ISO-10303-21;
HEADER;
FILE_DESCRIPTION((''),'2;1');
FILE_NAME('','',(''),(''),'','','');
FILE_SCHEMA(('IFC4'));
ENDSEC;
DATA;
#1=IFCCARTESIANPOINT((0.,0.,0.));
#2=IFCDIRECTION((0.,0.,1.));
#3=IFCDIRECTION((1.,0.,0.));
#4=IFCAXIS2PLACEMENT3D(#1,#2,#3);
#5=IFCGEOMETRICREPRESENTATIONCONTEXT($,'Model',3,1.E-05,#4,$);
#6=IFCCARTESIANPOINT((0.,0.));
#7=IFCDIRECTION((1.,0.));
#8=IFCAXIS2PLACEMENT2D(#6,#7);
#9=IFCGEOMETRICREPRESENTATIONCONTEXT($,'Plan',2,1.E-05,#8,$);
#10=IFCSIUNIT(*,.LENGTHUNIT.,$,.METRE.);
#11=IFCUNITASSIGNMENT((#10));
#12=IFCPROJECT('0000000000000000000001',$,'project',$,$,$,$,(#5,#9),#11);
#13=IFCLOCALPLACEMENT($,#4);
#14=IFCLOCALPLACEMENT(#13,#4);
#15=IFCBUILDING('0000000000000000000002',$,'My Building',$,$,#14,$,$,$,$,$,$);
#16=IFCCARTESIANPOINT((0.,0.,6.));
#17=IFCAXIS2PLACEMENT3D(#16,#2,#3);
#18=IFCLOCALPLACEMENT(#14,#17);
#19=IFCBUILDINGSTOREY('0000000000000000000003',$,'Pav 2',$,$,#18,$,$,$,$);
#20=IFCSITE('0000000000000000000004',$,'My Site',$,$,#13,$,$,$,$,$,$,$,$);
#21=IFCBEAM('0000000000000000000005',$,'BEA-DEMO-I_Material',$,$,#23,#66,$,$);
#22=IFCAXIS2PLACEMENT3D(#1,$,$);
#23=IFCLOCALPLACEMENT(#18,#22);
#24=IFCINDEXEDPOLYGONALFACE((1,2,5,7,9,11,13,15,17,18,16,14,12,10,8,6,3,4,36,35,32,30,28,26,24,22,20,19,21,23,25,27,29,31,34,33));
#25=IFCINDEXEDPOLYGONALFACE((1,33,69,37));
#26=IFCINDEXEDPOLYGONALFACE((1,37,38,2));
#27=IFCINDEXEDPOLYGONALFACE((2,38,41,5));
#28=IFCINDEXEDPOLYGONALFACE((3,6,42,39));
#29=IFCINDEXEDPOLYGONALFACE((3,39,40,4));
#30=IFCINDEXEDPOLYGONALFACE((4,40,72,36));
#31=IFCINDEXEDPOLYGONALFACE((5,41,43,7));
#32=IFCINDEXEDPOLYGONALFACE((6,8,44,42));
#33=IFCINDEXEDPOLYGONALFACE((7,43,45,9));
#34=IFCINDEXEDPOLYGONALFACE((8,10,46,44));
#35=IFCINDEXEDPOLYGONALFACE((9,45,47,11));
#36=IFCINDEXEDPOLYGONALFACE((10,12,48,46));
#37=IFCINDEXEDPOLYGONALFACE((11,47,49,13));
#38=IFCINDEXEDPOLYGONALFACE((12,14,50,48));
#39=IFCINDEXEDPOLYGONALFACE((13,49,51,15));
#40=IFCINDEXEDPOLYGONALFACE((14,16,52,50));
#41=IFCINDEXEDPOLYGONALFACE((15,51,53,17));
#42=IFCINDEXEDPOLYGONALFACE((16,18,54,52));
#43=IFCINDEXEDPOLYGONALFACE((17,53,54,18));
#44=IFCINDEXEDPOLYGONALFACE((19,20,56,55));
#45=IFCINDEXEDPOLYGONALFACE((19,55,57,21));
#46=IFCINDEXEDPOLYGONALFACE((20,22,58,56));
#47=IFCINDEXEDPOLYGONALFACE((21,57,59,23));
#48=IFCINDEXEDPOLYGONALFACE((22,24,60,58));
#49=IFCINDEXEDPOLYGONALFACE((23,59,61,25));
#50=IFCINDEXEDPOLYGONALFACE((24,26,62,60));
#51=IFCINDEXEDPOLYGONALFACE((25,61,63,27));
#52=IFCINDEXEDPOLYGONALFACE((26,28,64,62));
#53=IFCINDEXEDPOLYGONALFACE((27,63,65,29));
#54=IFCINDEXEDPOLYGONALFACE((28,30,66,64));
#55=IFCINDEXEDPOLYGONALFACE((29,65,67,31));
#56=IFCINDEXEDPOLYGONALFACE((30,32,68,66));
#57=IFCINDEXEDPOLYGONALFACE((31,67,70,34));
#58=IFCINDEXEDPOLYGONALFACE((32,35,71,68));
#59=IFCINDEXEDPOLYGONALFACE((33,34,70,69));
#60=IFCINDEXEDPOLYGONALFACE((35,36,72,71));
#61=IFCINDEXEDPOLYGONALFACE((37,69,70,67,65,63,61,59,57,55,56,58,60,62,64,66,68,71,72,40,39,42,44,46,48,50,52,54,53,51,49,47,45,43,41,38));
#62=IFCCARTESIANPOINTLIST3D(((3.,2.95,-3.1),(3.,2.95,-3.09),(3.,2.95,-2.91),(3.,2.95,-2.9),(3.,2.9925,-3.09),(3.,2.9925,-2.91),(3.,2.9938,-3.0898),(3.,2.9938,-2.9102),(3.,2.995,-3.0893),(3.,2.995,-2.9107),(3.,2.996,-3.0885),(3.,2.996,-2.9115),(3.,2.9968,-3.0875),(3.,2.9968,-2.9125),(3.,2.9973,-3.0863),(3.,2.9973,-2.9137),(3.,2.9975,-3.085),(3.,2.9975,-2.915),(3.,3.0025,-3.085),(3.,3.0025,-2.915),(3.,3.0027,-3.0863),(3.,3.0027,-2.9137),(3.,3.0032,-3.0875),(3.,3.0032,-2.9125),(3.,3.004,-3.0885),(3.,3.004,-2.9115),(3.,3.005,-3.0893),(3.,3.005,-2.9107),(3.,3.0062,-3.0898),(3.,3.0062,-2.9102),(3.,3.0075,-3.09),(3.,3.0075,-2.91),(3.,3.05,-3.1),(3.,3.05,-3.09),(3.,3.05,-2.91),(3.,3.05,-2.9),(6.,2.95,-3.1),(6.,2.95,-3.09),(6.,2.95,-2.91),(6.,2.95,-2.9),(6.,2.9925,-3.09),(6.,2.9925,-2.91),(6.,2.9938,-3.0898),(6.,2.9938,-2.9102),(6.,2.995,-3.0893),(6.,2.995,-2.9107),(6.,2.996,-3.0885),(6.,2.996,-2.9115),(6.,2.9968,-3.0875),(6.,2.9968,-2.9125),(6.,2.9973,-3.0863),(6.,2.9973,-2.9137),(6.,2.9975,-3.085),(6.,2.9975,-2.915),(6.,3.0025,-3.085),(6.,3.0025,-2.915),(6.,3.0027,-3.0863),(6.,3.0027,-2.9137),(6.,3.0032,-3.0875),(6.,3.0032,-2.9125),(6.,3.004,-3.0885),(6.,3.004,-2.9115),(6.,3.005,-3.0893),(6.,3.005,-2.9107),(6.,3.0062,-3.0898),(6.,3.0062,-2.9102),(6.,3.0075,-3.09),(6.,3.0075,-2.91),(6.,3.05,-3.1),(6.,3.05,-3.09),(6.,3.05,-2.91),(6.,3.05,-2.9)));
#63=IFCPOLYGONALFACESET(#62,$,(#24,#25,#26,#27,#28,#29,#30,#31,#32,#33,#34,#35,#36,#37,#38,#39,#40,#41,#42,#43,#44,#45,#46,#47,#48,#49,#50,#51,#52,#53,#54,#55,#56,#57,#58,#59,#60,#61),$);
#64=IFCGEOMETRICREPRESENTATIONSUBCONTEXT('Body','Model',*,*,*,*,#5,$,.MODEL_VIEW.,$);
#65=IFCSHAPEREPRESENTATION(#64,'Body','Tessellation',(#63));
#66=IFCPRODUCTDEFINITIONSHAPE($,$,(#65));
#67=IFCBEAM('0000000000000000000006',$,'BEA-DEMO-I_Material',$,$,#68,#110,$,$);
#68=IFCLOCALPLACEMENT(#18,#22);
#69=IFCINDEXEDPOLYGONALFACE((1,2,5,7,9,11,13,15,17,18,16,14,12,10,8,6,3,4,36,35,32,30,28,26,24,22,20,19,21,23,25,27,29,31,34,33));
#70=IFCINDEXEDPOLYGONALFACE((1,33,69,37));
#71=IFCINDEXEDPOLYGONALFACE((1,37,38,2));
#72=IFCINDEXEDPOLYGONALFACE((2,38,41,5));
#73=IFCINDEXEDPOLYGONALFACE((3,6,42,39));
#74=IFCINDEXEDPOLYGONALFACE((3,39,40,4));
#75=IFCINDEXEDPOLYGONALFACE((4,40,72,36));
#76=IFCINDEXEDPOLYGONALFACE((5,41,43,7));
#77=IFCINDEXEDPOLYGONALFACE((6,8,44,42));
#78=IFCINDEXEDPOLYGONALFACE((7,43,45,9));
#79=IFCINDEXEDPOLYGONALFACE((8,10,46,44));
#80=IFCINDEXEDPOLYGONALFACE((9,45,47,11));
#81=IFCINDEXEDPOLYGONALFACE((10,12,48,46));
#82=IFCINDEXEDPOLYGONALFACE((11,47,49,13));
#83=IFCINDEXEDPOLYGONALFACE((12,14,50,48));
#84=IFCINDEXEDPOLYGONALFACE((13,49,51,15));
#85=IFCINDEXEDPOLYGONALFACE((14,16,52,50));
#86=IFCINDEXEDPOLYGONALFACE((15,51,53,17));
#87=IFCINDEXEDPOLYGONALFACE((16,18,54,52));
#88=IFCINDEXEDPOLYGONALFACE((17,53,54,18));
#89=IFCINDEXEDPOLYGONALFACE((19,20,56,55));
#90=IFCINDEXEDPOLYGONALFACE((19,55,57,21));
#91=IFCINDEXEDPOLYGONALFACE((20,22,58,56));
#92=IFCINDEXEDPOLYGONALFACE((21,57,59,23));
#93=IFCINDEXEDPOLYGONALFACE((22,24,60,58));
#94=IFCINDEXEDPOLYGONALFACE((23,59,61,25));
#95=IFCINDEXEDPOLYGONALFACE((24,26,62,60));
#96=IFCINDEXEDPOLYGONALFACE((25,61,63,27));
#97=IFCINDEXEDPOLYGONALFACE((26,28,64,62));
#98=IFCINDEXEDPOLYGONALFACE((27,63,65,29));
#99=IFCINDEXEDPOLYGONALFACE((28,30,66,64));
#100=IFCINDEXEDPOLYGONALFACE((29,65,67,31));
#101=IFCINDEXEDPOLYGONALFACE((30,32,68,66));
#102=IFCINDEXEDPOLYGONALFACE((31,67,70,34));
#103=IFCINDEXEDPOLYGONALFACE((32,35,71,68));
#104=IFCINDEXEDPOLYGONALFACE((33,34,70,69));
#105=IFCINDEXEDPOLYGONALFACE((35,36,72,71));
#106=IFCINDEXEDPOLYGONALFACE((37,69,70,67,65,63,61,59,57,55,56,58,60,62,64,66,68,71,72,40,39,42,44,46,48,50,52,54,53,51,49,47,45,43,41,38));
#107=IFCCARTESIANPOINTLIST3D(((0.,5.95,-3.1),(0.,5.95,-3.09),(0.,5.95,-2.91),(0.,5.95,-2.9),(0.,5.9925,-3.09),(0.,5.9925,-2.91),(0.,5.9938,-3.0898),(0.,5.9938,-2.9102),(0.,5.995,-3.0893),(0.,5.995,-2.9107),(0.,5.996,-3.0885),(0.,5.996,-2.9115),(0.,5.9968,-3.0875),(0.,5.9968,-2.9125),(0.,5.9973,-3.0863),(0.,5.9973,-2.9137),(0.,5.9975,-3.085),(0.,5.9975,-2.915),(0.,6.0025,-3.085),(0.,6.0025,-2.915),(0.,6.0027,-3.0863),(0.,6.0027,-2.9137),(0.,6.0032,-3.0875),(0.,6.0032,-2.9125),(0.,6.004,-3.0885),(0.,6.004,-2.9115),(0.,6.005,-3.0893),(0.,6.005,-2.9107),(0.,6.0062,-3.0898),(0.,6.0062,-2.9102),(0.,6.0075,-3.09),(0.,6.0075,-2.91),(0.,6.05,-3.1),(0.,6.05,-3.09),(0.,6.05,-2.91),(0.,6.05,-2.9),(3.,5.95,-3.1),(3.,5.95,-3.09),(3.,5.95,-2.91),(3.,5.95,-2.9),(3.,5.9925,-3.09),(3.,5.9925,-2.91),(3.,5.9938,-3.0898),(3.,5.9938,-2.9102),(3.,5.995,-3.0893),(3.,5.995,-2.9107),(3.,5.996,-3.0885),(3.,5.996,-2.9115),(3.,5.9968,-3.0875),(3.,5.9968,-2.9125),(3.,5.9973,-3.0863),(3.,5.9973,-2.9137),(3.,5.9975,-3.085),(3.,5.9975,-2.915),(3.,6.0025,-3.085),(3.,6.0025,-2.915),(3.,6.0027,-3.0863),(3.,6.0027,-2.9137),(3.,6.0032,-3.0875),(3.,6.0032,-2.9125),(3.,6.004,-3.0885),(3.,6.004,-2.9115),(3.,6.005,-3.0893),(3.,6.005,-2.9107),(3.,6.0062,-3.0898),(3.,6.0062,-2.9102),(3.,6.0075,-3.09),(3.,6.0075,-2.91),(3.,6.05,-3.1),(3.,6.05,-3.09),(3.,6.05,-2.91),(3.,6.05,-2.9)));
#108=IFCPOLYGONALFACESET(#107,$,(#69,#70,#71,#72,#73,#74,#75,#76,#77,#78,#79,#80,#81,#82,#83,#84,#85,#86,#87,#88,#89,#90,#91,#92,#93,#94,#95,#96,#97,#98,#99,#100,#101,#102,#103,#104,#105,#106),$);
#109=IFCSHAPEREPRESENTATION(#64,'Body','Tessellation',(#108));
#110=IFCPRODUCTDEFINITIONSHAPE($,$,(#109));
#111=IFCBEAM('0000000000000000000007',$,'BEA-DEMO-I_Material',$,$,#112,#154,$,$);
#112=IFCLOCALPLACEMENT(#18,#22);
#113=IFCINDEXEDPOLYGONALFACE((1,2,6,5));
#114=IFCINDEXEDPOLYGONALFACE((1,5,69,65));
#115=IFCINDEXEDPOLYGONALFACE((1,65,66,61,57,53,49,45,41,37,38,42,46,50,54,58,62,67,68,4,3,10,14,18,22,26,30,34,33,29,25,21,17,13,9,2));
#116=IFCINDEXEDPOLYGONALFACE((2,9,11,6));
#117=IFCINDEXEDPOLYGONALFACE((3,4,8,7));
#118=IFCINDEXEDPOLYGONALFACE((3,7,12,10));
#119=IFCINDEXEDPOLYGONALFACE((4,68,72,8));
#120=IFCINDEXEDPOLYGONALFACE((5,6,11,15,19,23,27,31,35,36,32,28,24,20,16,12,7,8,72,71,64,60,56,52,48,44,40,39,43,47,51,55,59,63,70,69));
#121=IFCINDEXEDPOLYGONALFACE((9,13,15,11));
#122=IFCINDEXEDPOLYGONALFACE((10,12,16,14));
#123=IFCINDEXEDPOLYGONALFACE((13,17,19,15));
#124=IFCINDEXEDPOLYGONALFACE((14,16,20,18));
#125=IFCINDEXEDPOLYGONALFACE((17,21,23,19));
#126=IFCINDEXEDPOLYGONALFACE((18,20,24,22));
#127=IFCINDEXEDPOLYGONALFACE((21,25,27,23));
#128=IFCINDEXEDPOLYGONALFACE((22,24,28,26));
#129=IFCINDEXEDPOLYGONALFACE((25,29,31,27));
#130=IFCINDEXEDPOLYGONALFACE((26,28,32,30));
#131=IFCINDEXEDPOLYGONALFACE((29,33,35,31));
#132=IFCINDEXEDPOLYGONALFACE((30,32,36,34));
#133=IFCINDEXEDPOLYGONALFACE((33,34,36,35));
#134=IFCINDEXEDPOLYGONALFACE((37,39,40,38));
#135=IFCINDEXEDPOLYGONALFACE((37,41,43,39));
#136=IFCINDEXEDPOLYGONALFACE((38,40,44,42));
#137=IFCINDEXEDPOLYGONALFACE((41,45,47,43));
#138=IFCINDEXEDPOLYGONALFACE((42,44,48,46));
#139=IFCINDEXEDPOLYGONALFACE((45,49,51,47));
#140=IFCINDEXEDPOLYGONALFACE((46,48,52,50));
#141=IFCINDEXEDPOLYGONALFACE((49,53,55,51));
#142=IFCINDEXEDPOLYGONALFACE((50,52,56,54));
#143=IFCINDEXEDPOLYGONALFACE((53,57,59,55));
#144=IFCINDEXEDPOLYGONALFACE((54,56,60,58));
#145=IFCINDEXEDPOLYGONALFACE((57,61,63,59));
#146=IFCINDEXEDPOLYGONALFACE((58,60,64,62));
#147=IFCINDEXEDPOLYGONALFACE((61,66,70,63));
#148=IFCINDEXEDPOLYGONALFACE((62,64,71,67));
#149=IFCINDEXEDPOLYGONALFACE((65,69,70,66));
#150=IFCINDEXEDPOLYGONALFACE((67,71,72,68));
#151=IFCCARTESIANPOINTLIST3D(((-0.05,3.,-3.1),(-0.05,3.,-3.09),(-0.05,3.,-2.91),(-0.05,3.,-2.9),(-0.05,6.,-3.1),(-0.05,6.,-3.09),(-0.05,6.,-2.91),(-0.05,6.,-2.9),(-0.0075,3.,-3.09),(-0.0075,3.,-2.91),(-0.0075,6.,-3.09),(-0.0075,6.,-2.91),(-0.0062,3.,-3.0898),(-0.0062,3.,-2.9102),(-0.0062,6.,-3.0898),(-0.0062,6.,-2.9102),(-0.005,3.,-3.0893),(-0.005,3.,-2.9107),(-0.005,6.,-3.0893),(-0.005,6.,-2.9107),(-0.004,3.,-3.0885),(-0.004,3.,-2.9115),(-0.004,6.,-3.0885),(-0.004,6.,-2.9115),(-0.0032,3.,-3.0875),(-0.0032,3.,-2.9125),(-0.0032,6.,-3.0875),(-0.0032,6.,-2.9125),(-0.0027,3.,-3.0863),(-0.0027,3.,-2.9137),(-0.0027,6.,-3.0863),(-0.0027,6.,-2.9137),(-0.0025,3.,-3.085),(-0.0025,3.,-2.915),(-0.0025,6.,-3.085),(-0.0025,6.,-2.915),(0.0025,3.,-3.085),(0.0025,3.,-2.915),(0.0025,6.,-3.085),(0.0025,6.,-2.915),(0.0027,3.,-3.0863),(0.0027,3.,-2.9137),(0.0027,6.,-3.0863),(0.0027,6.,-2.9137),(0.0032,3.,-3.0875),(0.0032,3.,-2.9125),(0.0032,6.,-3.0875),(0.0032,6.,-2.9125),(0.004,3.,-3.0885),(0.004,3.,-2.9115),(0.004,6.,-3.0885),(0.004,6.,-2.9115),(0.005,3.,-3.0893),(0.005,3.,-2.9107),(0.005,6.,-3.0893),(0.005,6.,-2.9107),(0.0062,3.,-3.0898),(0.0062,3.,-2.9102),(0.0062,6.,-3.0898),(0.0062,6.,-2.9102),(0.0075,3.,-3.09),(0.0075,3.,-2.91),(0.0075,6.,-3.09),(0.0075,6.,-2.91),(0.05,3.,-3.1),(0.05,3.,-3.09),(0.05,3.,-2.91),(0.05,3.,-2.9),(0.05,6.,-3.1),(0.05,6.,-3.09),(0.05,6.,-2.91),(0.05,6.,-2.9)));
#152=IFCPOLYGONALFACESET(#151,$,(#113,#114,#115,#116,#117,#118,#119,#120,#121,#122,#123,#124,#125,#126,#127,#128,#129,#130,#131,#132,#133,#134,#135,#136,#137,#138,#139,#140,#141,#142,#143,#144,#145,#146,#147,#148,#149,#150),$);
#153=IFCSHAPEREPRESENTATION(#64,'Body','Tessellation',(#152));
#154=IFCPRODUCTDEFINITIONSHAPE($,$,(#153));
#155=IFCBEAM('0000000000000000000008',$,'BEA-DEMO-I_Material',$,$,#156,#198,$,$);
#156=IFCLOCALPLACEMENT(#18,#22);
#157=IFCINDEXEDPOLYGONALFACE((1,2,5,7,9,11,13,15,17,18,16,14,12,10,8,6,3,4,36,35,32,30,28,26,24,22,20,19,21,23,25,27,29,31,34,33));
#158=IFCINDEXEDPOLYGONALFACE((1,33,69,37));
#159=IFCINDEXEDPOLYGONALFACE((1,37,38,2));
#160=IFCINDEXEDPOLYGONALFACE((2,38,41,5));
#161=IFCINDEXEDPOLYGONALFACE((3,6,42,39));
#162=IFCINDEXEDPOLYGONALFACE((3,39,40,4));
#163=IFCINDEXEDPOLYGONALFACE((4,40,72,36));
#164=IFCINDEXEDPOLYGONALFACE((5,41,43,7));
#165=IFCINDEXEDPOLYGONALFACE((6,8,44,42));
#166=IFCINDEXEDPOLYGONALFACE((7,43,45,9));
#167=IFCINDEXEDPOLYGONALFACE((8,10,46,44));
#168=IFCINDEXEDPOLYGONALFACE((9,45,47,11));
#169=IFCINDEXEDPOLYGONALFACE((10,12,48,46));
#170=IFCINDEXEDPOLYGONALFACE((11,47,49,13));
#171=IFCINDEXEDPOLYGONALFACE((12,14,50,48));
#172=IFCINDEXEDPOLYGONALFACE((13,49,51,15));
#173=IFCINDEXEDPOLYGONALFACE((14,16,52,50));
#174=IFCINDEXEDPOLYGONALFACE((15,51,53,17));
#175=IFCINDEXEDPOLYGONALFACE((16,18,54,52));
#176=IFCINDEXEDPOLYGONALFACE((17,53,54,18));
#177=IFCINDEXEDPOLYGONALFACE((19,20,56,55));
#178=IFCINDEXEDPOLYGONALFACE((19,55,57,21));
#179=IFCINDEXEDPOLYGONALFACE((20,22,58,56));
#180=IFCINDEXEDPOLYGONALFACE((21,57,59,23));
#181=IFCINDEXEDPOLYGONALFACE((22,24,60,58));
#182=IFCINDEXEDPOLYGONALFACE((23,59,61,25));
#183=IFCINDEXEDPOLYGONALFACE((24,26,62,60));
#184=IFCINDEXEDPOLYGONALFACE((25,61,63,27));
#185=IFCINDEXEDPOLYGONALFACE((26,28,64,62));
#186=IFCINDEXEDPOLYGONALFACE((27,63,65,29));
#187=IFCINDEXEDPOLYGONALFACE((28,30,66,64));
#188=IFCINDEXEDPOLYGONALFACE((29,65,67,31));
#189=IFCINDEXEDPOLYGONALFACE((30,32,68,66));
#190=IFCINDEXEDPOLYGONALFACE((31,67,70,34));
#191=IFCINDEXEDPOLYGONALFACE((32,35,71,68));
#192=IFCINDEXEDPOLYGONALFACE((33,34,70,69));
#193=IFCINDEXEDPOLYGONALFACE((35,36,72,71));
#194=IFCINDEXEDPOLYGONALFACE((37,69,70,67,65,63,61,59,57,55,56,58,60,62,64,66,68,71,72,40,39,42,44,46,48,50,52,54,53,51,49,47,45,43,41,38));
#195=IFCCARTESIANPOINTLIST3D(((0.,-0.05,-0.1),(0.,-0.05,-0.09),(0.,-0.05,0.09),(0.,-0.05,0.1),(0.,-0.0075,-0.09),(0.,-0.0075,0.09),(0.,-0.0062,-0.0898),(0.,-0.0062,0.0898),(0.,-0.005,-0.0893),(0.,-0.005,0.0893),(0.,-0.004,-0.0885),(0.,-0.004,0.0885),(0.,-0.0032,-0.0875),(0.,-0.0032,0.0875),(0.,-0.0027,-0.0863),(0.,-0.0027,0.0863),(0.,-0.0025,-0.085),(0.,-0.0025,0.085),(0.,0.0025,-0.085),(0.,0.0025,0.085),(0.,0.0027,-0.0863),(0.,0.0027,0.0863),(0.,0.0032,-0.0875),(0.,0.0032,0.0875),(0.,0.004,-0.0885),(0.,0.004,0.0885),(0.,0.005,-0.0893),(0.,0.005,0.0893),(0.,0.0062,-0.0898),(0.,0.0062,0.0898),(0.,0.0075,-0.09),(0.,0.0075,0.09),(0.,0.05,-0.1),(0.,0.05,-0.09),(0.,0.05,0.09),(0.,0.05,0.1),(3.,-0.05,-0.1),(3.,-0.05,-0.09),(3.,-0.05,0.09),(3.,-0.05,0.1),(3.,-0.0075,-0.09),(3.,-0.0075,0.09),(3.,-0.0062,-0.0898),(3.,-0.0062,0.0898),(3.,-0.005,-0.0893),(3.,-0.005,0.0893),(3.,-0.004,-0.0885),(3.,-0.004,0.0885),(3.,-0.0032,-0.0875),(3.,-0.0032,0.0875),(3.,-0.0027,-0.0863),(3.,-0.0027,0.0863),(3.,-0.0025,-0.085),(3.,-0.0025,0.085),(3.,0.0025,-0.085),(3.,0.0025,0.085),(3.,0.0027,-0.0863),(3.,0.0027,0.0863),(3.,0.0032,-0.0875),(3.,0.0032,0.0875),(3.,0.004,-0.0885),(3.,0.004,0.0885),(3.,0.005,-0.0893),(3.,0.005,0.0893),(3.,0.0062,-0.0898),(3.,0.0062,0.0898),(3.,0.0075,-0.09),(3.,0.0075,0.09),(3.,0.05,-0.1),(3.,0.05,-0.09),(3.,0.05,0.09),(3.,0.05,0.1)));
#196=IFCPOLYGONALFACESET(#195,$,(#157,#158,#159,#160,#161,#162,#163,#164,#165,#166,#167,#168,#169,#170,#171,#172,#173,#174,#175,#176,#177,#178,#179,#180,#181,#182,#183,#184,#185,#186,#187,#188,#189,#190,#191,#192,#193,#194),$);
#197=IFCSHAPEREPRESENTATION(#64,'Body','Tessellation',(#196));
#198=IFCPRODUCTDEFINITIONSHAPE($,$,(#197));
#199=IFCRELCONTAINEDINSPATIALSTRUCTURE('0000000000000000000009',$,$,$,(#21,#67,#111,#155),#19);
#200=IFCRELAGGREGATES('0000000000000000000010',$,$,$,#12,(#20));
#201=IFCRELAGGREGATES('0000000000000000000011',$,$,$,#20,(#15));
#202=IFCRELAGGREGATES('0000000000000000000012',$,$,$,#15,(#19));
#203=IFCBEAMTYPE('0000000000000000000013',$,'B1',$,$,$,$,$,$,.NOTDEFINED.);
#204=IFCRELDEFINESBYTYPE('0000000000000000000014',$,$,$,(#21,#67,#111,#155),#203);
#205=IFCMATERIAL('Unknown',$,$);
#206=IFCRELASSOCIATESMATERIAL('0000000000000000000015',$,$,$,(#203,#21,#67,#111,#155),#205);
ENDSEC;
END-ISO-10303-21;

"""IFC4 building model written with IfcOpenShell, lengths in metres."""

from ifc_helpers import new_model, si_unit, frame, origin, origin_with_axes, origin_2d_with_axis, place, context, subcontext, project, spatial, i_section, extrude, material, material_profile, profile_set, profile_usage, type_object, element, save


model = new_model("IFC4")

# Units and contexts
model_context = context("Model", 3, precision=1e-05, world=origin_with_axes())
plan_context = context("Plan", 2, precision=1e-05, world=origin_2d_with_axis())
body_context = subcontext(model_context, "Body", "Model", "MODEL_VIEW")
ifc_project = project(units=[si_unit("LENGTHUNIT", "METRE")], contexts=[model_context, plan_context])

# Site, building, storey
site_placement = place(None, origin_with_axes())
site = spatial("IfcSite", under=ifc_project, at=site_placement, Name="My Site")
building_placement = place(site_placement, origin_with_axes())
building = spatial("IfcBuilding", under=site, at=building_placement, Name="My Building")
storey_placement = place(building_placement, frame((0.0, 0.0, 6.0), z_axis=(0.0, 0.0, 1.0), x_axis=(1.0, 0.0, 0.0)))
storey = spatial("IfcBuildingStorey", under=building, at=storey_placement, Name="Pav 2")

# Beams
ifc_material = material(Name="Unknown")
ifc_material_profile = material_profile(ifc_material, i_section(OverallWidth=0.1, OverallDepth=0.2, WebThickness=0.005, FlangeThickness=0.01, FilletRadius=0.005))
ifc_profile_set = profile_set([ifc_material_profile])
beam_type = type_object("IfcBeamType", Name="B1", PredefinedType="NOTDEFINED", material=ifc_profile_set)
ifc_profile_usage_1 = profile_usage(ifc_profile_set, cardinal=5)
beam_1_placement = place(storey_placement, frame((3.0, 3.0, -3.0), z_axis=(1.0, 0.0, 0.0), x_axis=(0.0, 1.0, 0.0)))
element("IfcBeam", 1, at=beam_1_placement, inside=storey, type_object=beam_type, material=ifc_profile_usage_1, Name="BEA-DEMO-I_Material", context=body_context, shape_type="SweptSolid", body=[
    extrude(i_section(OverallWidth=0.1, OverallDepth=0.2, WebThickness=0.005, FlangeThickness=0.01, FilletRadius=0.005), origin(), (0.0, 0.0, 1.0), 3.0),
])
ifc_profile_usage_2 = profile_usage(ifc_profile_set, cardinal=5)
beam_2_placement = place(storey_placement, frame((0.0, 6.0, -3.0), z_axis=(1.0, 0.0, 0.0), x_axis=(0.0, 1.0, 0.0)))
element("IfcBeam", 2, at=beam_2_placement, inside=storey, type_object=beam_type, material=ifc_profile_usage_2, Name="BEA-DEMO-I_Material", context=body_context, shape_type="SweptSolid", body=[
    extrude(i_section(OverallWidth=0.1, OverallDepth=0.2, WebThickness=0.005, FlangeThickness=0.01, FilletRadius=0.005), origin(), (0.0, 0.0, 1.0), 3.0),
])
ifc_profile_usage_3 = profile_usage(ifc_profile_set, cardinal=5)
beam_3_placement = place(storey_placement, frame((0.0, 3.0, -3.0), z_axis=(0.0, 1.0, 0.0), x_axis=(-1.0, 0.0, 0.0)))
element("IfcBeam", 3, at=beam_3_placement, inside=storey, type_object=beam_type, material=ifc_profile_usage_3, Name="BEA-DEMO-I_Material", context=body_context, shape_type="SweptSolid", body=[
    extrude(i_section(OverallWidth=0.1, OverallDepth=0.2, WebThickness=0.005, FlangeThickness=0.01, FilletRadius=0.005), origin(), (0.0, 0.0, 1.0), 3.0),
])
ifc_profile_usage_4 = profile_usage(ifc_profile_set, cardinal=5)
beam_4_placement = place(storey_placement, frame((3.0, 0.0, 0.0), z_axis=(-1.0, 0.0, 0.0), x_axis=(0.0, -1.0, 0.0)))
element("IfcBeam", 4, at=beam_4_placement, inside=storey, type_object=beam_type, material=ifc_profile_usage_4, Name="BEA-DEMO-I_Material", context=body_context, shape_type="SweptSolid", body=[
    extrude(i_section(OverallWidth=0.1, OverallDepth=0.2, WebThickness=0.005, FlangeThickness=0.01, FilletRadius=0.005), origin(), (0.0, 0.0, 1.0), 3.0),
])

save(model, "model.ifc")
